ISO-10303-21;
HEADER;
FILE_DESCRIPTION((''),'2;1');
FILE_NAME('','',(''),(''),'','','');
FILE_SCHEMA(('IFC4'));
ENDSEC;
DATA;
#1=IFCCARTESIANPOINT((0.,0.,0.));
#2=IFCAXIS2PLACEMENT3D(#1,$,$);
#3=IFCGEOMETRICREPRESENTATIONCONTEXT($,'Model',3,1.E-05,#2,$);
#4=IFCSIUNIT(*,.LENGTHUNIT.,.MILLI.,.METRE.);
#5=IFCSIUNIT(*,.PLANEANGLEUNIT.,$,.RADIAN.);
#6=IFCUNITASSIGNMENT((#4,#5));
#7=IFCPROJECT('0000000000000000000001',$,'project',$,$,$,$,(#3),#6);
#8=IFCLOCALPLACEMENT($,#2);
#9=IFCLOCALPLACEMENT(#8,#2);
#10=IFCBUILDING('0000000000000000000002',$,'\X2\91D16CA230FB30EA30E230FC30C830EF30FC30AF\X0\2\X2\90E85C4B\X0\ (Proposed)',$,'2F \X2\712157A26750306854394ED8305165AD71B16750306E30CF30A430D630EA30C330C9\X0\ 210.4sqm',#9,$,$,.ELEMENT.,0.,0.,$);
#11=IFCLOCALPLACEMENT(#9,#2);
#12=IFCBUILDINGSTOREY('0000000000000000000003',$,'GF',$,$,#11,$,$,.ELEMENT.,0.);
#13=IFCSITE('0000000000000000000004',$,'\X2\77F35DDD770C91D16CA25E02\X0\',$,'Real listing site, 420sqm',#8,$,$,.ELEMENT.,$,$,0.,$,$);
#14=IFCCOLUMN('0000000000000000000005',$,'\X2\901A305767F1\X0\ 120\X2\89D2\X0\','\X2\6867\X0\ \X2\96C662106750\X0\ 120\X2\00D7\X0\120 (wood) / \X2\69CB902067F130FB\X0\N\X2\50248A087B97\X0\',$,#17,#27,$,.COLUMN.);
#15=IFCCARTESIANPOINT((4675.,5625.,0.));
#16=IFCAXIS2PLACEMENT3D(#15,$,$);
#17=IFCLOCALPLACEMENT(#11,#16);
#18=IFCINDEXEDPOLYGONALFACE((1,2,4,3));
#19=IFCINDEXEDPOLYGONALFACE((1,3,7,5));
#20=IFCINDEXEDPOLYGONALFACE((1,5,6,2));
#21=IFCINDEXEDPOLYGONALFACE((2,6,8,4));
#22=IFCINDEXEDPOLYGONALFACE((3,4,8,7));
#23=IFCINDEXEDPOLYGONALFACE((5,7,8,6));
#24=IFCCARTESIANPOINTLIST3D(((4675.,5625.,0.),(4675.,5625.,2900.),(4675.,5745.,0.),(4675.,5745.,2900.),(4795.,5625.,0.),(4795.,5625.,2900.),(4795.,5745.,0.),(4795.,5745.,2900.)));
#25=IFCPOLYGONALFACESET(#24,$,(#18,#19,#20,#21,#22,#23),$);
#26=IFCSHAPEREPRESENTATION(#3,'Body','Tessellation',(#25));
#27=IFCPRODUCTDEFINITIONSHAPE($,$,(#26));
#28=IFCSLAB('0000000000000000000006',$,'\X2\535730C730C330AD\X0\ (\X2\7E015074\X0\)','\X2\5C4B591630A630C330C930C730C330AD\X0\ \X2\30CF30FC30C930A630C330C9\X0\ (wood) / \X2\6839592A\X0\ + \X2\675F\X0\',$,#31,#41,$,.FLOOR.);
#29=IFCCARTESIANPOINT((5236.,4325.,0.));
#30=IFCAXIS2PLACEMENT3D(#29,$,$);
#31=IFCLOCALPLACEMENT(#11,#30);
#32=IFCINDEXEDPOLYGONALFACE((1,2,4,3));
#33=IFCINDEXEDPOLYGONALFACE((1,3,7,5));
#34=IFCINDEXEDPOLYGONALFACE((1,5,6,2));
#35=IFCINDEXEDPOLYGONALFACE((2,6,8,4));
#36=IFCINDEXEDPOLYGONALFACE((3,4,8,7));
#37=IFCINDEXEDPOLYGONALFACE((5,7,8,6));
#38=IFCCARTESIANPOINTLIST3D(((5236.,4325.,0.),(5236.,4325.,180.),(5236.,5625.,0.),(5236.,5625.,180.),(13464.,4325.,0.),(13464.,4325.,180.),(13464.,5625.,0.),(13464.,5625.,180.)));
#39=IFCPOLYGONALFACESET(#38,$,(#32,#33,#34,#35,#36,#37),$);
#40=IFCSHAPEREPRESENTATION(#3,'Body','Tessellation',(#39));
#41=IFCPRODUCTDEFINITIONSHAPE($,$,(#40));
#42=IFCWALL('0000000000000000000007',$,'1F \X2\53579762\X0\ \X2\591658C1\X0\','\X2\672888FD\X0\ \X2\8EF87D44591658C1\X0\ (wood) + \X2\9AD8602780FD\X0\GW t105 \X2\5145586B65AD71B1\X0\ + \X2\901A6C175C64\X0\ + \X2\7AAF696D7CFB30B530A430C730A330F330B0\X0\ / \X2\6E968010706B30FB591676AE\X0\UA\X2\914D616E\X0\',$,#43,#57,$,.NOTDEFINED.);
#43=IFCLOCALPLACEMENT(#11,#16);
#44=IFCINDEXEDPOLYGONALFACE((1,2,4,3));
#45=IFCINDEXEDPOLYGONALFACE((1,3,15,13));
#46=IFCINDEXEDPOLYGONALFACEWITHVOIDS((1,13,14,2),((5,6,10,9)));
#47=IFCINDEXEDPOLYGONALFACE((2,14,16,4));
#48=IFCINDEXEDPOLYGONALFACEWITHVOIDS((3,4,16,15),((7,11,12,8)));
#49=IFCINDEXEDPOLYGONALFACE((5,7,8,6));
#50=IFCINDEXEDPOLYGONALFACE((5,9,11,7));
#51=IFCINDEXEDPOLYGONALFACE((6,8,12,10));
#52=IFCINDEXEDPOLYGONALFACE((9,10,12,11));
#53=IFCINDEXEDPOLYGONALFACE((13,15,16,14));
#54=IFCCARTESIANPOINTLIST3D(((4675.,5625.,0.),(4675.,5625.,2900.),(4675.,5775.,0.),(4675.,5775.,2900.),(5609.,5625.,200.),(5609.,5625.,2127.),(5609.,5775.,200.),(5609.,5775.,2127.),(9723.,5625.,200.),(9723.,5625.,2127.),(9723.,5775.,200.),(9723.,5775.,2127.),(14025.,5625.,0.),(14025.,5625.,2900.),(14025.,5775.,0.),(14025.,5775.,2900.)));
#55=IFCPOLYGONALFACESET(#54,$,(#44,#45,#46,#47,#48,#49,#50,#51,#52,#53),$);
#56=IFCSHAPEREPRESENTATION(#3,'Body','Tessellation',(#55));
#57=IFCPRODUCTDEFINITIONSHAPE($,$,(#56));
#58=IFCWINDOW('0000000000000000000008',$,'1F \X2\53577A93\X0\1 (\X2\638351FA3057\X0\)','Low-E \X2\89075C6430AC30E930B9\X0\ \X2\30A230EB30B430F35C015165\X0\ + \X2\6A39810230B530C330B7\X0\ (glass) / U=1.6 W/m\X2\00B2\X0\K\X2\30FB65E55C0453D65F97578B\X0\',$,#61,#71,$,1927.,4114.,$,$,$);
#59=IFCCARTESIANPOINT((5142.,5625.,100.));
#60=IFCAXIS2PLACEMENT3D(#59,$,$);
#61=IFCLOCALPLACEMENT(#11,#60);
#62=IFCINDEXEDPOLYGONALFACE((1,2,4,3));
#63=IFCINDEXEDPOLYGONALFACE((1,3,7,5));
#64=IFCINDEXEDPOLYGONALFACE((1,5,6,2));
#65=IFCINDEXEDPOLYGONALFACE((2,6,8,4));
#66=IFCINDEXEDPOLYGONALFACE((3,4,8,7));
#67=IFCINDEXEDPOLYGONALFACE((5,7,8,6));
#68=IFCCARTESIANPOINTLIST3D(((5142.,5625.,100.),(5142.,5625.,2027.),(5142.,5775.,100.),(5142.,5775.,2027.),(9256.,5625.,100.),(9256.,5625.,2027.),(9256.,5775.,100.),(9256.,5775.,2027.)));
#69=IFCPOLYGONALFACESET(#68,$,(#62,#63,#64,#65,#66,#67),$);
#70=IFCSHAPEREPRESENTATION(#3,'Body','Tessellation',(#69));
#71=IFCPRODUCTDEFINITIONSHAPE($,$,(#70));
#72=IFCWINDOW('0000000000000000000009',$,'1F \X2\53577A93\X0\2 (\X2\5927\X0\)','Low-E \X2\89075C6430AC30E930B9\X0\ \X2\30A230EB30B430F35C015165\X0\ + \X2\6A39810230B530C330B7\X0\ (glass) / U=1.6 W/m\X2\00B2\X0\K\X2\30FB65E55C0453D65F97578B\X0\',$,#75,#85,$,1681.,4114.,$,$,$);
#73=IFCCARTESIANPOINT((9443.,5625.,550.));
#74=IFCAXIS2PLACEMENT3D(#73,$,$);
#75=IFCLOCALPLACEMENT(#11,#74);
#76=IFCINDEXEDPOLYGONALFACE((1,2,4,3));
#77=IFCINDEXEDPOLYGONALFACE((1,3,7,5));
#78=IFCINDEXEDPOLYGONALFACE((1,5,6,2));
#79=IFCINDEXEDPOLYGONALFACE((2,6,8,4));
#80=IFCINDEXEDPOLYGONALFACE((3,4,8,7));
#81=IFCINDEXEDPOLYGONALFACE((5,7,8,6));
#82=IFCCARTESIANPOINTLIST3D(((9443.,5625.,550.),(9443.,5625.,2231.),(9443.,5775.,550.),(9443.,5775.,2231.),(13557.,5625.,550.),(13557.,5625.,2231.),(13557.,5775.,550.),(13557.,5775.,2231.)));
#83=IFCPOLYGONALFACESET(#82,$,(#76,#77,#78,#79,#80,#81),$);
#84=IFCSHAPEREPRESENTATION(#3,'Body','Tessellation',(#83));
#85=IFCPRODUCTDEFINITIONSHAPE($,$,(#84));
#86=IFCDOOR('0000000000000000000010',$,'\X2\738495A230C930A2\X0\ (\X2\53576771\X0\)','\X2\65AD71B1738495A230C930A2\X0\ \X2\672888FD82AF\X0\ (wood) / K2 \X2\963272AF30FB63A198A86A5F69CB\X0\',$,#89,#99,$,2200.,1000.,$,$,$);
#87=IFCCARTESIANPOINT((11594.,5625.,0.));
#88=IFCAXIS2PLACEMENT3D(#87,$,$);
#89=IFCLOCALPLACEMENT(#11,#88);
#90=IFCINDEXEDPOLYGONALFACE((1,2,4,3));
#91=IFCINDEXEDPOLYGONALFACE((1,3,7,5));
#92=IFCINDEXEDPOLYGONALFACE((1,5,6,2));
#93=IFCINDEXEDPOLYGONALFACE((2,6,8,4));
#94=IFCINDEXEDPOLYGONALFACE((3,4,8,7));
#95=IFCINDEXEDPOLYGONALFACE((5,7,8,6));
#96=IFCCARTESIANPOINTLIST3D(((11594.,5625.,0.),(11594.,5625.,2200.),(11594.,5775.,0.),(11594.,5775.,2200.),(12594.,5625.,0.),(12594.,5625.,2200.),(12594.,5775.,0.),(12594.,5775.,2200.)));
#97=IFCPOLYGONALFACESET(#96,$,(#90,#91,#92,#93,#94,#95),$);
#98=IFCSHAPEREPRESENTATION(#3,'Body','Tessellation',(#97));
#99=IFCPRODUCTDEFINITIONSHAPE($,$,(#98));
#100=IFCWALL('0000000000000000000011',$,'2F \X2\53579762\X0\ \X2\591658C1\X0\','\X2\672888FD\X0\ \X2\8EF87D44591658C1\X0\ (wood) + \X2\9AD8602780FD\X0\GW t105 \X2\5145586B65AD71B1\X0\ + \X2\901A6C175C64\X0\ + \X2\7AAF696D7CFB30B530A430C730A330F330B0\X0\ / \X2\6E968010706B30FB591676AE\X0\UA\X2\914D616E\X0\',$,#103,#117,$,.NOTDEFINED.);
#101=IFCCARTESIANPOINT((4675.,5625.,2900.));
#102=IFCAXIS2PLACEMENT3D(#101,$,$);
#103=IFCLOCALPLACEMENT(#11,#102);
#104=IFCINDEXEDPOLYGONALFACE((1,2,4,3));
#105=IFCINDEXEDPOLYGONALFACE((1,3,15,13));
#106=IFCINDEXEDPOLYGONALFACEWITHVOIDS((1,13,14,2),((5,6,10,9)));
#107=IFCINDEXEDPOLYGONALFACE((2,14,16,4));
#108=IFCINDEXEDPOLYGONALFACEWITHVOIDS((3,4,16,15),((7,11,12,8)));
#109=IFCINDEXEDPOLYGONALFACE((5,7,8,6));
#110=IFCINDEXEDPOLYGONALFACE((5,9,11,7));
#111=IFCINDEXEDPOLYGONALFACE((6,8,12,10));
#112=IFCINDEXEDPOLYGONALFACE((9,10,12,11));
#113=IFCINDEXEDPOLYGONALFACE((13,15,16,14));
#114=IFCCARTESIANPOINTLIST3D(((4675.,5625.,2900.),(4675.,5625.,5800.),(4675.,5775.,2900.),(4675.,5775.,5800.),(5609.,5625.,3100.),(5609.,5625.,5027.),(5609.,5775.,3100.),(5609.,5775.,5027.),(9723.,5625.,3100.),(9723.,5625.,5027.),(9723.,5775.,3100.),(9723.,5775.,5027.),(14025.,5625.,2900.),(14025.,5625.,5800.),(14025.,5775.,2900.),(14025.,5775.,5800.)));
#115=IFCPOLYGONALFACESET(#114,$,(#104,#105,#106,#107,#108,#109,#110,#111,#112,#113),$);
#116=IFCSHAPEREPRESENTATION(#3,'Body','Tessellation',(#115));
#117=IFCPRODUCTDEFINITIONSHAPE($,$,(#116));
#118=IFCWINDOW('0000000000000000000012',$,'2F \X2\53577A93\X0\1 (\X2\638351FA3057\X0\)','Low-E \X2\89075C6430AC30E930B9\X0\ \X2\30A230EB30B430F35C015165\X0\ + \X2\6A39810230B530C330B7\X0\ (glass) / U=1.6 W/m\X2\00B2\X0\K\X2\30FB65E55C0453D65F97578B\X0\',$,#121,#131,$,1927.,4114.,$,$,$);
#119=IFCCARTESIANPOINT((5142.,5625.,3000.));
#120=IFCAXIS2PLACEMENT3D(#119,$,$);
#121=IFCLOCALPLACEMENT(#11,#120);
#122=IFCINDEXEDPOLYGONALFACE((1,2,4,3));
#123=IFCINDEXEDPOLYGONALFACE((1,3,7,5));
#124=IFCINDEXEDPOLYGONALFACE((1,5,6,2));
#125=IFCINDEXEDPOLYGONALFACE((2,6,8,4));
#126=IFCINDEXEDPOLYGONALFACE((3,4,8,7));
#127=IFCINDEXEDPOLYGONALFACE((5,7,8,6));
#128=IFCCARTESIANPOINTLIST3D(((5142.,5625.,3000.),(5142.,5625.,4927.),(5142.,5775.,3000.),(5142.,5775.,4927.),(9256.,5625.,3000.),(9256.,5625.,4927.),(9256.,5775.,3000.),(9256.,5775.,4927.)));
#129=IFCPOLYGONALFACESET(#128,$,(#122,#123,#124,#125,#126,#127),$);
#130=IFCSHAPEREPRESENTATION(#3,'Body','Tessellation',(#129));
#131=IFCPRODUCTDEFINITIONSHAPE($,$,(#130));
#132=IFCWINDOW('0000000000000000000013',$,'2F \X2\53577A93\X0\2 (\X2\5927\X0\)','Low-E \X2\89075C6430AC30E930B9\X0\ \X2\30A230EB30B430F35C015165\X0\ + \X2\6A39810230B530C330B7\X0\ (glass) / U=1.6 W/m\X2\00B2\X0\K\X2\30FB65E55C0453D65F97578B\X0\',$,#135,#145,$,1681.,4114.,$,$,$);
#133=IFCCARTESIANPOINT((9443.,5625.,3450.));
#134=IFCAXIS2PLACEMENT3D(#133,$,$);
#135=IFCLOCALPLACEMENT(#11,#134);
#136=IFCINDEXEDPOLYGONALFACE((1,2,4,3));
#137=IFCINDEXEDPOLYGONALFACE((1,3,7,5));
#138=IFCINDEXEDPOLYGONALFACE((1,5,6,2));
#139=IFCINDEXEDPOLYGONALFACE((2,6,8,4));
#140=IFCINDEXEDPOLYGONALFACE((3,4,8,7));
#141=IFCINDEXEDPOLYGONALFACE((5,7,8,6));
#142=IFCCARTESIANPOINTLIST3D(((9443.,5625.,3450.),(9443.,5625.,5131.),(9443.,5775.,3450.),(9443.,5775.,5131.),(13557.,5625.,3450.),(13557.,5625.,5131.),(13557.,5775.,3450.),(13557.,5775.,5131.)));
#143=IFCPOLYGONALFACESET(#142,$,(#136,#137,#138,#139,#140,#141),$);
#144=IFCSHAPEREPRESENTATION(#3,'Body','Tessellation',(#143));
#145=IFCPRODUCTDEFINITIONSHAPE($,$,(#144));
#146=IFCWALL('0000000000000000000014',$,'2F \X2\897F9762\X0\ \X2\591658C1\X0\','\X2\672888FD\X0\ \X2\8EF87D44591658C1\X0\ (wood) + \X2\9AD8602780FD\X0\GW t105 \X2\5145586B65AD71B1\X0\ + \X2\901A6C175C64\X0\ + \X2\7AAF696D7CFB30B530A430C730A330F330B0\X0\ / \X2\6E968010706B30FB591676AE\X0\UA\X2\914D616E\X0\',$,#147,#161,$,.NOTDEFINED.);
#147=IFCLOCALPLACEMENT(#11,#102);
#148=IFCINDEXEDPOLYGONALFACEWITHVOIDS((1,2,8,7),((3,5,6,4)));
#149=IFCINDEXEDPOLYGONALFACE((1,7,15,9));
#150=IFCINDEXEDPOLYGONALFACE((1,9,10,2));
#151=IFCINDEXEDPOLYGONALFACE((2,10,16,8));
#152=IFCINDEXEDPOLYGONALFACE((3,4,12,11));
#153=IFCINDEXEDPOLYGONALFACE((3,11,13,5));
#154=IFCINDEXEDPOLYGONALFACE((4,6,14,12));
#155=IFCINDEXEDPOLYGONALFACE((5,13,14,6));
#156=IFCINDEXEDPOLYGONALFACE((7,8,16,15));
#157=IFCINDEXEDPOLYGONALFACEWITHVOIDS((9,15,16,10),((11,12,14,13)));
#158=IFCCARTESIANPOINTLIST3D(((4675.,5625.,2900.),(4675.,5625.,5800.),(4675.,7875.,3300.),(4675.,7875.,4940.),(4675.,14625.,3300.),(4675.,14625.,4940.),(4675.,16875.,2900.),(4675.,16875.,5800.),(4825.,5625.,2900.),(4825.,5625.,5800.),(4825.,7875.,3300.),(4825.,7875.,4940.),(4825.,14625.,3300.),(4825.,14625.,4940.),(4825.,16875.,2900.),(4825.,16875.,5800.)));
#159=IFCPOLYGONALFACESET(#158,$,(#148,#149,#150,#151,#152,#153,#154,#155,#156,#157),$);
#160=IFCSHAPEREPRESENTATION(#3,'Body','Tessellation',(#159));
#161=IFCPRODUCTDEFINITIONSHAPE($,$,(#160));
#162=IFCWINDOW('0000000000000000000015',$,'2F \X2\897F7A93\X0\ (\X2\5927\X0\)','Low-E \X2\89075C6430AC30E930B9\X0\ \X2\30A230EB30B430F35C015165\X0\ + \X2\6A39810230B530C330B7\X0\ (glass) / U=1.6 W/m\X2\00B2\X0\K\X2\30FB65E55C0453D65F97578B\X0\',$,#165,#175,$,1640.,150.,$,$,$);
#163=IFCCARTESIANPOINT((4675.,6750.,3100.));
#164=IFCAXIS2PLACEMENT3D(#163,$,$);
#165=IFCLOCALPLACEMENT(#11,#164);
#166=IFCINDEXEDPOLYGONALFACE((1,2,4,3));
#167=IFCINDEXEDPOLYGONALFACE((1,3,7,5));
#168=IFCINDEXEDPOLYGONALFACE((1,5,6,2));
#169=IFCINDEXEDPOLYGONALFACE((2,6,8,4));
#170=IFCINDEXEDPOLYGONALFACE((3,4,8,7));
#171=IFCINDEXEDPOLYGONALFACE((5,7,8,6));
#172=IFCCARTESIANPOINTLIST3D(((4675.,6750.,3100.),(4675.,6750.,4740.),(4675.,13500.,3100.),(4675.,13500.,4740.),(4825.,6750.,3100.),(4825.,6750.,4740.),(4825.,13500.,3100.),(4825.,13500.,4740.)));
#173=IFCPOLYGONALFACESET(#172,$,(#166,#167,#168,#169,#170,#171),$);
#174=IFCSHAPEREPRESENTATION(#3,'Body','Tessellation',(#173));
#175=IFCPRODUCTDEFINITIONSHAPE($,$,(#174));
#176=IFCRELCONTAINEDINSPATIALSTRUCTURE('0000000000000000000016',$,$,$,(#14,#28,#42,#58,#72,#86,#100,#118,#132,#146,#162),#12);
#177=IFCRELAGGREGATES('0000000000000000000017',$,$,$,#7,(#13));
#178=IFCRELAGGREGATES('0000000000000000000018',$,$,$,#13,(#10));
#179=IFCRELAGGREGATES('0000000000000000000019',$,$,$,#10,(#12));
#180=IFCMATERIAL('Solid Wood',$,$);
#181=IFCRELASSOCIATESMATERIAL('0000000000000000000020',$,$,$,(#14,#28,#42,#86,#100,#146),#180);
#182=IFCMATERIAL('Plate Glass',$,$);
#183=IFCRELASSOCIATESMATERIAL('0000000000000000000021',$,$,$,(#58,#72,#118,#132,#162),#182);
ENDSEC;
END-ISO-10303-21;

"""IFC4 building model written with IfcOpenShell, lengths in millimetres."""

from ifc_helpers import new_model, si_unit, frame, frame_2d, origin, place, context, project, spatial, rectangle, extrude, material, element, fill, save


model = new_model("IFC4")

# Units and contexts
model_context = context("Model", 3, precision=1e-05, world=origin())
ifc_project = project(units=[si_unit("LENGTHUNIT", "METRE", prefix="MILLI"), si_unit("PLANEANGLEUNIT", "RADIAN")], contexts=[model_context])

# Site, building, storey
site_placement = place(None, origin())
site = spatial("IfcSite", under=ifc_project, at=site_placement, Name="石川県金沢市", ObjectType="Real listing site, 420sqm", CompositionType="ELEMENT", RefElevation=0.0)
building_placement = place(site_placement, origin())
building = spatial("IfcBuilding", under=site, at=building_placement, Name="金沢・リモートワーク2部屋 (Proposed)", ObjectType="2F 無垢材と吹付け断熱材のハイブリッド 210.4sqm", CompositionType="ELEMENT", ElevationOfRefHeight=0.0, ElevationOfTerrain=0.0)
storey_placement = place(building_placement, origin())
storey = spatial("IfcBuildingStorey", under=building, at=storey_placement, Name="GF", CompositionType="ELEMENT", Elevation=0.0)

# Column
ifc_material_1 = material(Name="Solid Wood")
column_placement = place(storey_placement, frame((4675.0, 5625.0, 0.0)))
element("IfcColumn", 1, at=column_placement, inside=storey, material=ifc_material_1, Name="通し柱 120角", Description="桧 集成材 120×120 (wood) / 構造柱・N値計算", PredefinedType="COLUMN", context=model_context, shape_type="SweptSolid", body=[
    extrude(rectangle(XDim=120.0, YDim=120.0, at=frame_2d((60.0, 60.0))), frame((4675.0, 5625.0, 0.0)), (0.0, 0.0, 1.0), 2900.0),
])

# Slab
slab_1_placement = place(storey_placement, frame((5236.0, 4325.0, 0.0)))
element("IfcSlab", 2, at=slab_1_placement, inside=storey, material=ifc_material_1, Name="南デッキ (縁側)", Description="屋外ウッドデッキ ハードウッド (wood) / 根太 + 束", PredefinedType="FLOOR", context=model_context, shape_type="SweptSolid", body=[
    extrude(rectangle(XDim=8228.0, YDim=1300.0, at=frame_2d((4114.0, 650.0))), frame((5236.0, 4325.0, 0.0)), (0.0, 0.0, 1.0), 180.0),
])

# Wall, openings, windows, door
wall_1_placement = place(storey_placement, frame((4675.0, 5625.0, 0.0)))
wall_1 = element("IfcWall", 3, at=wall_1_placement, inside=storey, material=ifc_material_1, Name="1F 南面 外壁", Description="木製 軸組外壁 (wood) + 高性能GW t105 充填断熱 + 通気層 + 窯業系サイディング / 準耐火・外皮UA配慮", PredefinedType="NOTDEFINED", context=model_context, shape_type="SweptSolid", body=[
    extrude(rectangle(XDim=9350.0, YDim=150.0, at=frame_2d((4675.0, 75.0))), frame((4675.0, 5625.0, 0.0)), (0.0, 0.0, 1.0), 2900.0),
])
opening_1_placement = place(storey_placement, frame((5142.0, 5625.0, 100.0)))
opening_1 = element("IfcOpeningElement", 4, at=opening_1_placement, cuts=wall_1, PredefinedType="NOTDEFINED", context=model_context, shape_type="SweptSolid", body=[
    extrude(rectangle(XDim=4114.0, YDim=150.0, at=frame_2d((2057.0, 75.0))), frame((5142.0, 5625.0, 100.0)), (0.0, 0.0, 1.0), 1927.0),
])
opening_2_placement = place(storey_placement, frame((9443.0, 5625.0, 550.0)))
opening_2 = element("IfcOpeningElement", 5, at=opening_2_placement, cuts=wall_1, PredefinedType="NOTDEFINED", context=model_context, shape_type="SweptSolid", body=[
    extrude(rectangle(XDim=4114.0, YDim=150.0, at=frame_2d((2057.0, 75.0))), frame((9443.0, 5625.0, 550.0)), (0.0, 0.0, 1.0), 1681.0),
])
opening_3_placement = place(storey_placement, frame((11594.0, 5625.0, 0.0)))
opening_3 = element("IfcOpeningElement", 6, at=opening_3_placement, cuts=wall_1, PredefinedType="NOTDEFINED", context=model_context, shape_type="SweptSolid", body=[
    extrude(rectangle(XDim=1000.0, YDim=150.0, at=frame_2d((500.0, 75.0))), frame((11594.0, 5625.0, 0.0)), (0.0, 0.0, 1.0), 2200.0),
])
ifc_material_2 = material(Name="Plate Glass")
window_1_placement = place(storey_placement, frame((5142.0, 5625.0, 100.0)))
window_1 = element("IfcWindow", 7, at=window_1_placement, inside=storey, material=ifc_material_2, Name="1F 南窓1 (掃出し)", Description="Low-E 複層ガラス アルゴン封入 + 樹脂サッシ (glass) / U=1.6 W/m²K・日射取得型", OverallHeight=1927.0, OverallWidth=4114.0, context=model_context, shape_type="SweptSolid", body=[
    extrude(rectangle(XDim=4114.0, YDim=150.0, at=frame_2d((2057.0, 75.0))), frame((5142.0, 5625.0, 100.0)), (0.0, 0.0, 1.0), 1927.0),
])
fill(opening_1, window_1)
window_2_placement = place(storey_placement, frame((9443.0, 5625.0, 550.0)))
window_2 = element("IfcWindow", 8, at=window_2_placement, inside=storey, material=ifc_material_2, Name="1F 南窓2 (大)", Description="Low-E 複層ガラス アルゴン封入 + 樹脂サッシ (glass) / U=1.6 W/m²K・日射取得型", OverallHeight=1681.0, OverallWidth=4114.0, context=model_context, shape_type="SweptSolid", body=[
    extrude(rectangle(XDim=4114.0, YDim=150.0, at=frame_2d((2057.0, 75.0))), frame((9443.0, 5625.0, 550.0)), (0.0, 0.0, 1.0), 1681.0),
])
fill(opening_2, window_2)
door_placement = place(storey_placement, frame((11594.0, 5625.0, 0.0)))
door = element("IfcDoor", 9, at=door_placement, inside=storey, material=ifc_material_1, Name="玄関ドア (南東)", Description="断熱玄関ドア 木製芯 (wood) / K2 防犯・採風機構", OverallHeight=2200.0, OverallWidth=1000.0, context=model_context, shape_type="SweptSolid", body=[
    extrude(rectangle(XDim=1000.0, YDim=150.0, at=frame_2d((500.0, 75.0))), frame((11594.0, 5625.0, 0.0)), (0.0, 0.0, 1.0), 2200.0),
])
fill(opening_3, door)

# Wall, openings, windows
wall_2_placement = place(storey_placement, frame((4675.0, 5625.0, 2900.0)))
wall_2 = element("IfcWall", 10, at=wall_2_placement, inside=storey, material=ifc_material_1, Name="2F 南面 外壁", Description="木製 軸組外壁 (wood) + 高性能GW t105 充填断熱 + 通気層 + 窯業系サイディング / 準耐火・外皮UA配慮", PredefinedType="NOTDEFINED", context=model_context, shape_type="SweptSolid", body=[
    extrude(rectangle(XDim=9350.0, YDim=150.0, at=frame_2d((4675.0, 75.0))), frame((4675.0, 5625.0, 2900.0)), (0.0, 0.0, 1.0), 2900.0),
])
opening_4_placement = place(storey_placement, frame((5142.0, 5625.0, 3000.0)))
opening_4 = element("IfcOpeningElement", 11, at=opening_4_placement, cuts=wall_2, PredefinedType="NOTDEFINED", context=model_context, shape_type="SweptSolid", body=[
    extrude(rectangle(XDim=4114.0, YDim=150.0, at=frame_2d((2057.0, 75.0))), frame((5142.0, 5625.0, 3000.0)), (0.0, 0.0, 1.0), 1927.0),
])
opening_5_placement = place(storey_placement, frame((9443.0, 5625.0, 3450.0)))
opening_5 = element("IfcOpeningElement", 12, at=opening_5_placement, cuts=wall_2, PredefinedType="NOTDEFINED", context=model_context, shape_type="SweptSolid", body=[
    extrude(rectangle(XDim=4114.0, YDim=150.0, at=frame_2d((2057.0, 75.0))), frame((9443.0, 5625.0, 3450.0)), (0.0, 0.0, 1.0), 1681.0),
])
window_3_placement = place(storey_placement, frame((5142.0, 5625.0, 3000.0)))
window_3 = element("IfcWindow", 13, at=window_3_placement, inside=storey, material=ifc_material_2, Name="2F 南窓1 (掃出し)", Description="Low-E 複層ガラス アルゴン封入 + 樹脂サッシ (glass) / U=1.6 W/m²K・日射取得型", OverallHeight=1927.0, OverallWidth=4114.0, context=model_context, shape_type="SweptSolid", body=[
    extrude(rectangle(XDim=4114.0, YDim=150.0, at=frame_2d((2057.0, 75.0))), frame((5142.0, 5625.0, 3000.0)), (0.0, 0.0, 1.0), 1927.0),
])
fill(opening_4, window_3)
window_4_placement = place(storey_placement, frame((9443.0, 5625.0, 3450.0)))
window_4 = element("IfcWindow", 14, at=window_4_placement, inside=storey, material=ifc_material_2, Name="2F 南窓2 (大)", Description="Low-E 複層ガラス アルゴン封入 + 樹脂サッシ (glass) / U=1.6 W/m²K・日射取得型", OverallHeight=1681.0, OverallWidth=4114.0, context=model_context, shape_type="SweptSolid", body=[
    extrude(rectangle(XDim=4114.0, YDim=150.0, at=frame_2d((2057.0, 75.0))), frame((9443.0, 5625.0, 3450.0)), (0.0, 0.0, 1.0), 1681.0),
])
fill(opening_5, window_4)

# Wall, opening, window
wall_3_placement = place(storey_placement, frame((4675.0, 5625.0, 2900.0)))
wall_3 = element("IfcWall", 15, at=wall_3_placement, inside=storey, material=ifc_material_1, Name="2F 西面 外壁", Description="木製 軸組外壁 (wood) + 高性能GW t105 充填断熱 + 通気層 + 窯業系サイディング / 準耐火・外皮UA配慮", PredefinedType="NOTDEFINED", context=model_context, shape_type="SweptSolid", body=[
    extrude(rectangle(XDim=150.0, YDim=11250.0, at=frame_2d((75.0, 5625.0))), frame((4675.0, 5625.0, 2900.0)), (0.0, 0.0, 1.0), 2900.0),
])
opening_6_placement = place(storey_placement, frame((4675.0, 6750.0, 3100.0)))
opening_6 = element("IfcOpeningElement", 16, at=opening_6_placement, cuts=wall_3, PredefinedType="NOTDEFINED", context=model_context, shape_type="SweptSolid", body=[
    extrude(rectangle(XDim=150.0, YDim=6750.0, at=frame_2d((75.0, 3375.0))), frame((4675.0, 6750.0, 3100.0)), (0.0, 0.0, 1.0), 1640.0),
])
window_5_placement = place(storey_placement, frame((4675.0, 6750.0, 3100.0)))
window_5 = element("IfcWindow", 17, at=window_5_placement, inside=storey, material=ifc_material_2, Name="2F 西窓 (大)", Description="Low-E 複層ガラス アルゴン封入 + 樹脂サッシ (glass) / U=1.6 W/m²K・日射取得型", OverallHeight=1640.0, OverallWidth=150.0, context=model_context, shape_type="SweptSolid", body=[
    extrude(rectangle(XDim=150.0, YDim=6750.0, at=frame_2d((75.0, 3375.0))), frame((4675.0, 6750.0, 3100.0)), (0.0, 0.0, 1.0), 1640.0),
])
fill(opening_6, window_5)

save(model, "model.ifc")
